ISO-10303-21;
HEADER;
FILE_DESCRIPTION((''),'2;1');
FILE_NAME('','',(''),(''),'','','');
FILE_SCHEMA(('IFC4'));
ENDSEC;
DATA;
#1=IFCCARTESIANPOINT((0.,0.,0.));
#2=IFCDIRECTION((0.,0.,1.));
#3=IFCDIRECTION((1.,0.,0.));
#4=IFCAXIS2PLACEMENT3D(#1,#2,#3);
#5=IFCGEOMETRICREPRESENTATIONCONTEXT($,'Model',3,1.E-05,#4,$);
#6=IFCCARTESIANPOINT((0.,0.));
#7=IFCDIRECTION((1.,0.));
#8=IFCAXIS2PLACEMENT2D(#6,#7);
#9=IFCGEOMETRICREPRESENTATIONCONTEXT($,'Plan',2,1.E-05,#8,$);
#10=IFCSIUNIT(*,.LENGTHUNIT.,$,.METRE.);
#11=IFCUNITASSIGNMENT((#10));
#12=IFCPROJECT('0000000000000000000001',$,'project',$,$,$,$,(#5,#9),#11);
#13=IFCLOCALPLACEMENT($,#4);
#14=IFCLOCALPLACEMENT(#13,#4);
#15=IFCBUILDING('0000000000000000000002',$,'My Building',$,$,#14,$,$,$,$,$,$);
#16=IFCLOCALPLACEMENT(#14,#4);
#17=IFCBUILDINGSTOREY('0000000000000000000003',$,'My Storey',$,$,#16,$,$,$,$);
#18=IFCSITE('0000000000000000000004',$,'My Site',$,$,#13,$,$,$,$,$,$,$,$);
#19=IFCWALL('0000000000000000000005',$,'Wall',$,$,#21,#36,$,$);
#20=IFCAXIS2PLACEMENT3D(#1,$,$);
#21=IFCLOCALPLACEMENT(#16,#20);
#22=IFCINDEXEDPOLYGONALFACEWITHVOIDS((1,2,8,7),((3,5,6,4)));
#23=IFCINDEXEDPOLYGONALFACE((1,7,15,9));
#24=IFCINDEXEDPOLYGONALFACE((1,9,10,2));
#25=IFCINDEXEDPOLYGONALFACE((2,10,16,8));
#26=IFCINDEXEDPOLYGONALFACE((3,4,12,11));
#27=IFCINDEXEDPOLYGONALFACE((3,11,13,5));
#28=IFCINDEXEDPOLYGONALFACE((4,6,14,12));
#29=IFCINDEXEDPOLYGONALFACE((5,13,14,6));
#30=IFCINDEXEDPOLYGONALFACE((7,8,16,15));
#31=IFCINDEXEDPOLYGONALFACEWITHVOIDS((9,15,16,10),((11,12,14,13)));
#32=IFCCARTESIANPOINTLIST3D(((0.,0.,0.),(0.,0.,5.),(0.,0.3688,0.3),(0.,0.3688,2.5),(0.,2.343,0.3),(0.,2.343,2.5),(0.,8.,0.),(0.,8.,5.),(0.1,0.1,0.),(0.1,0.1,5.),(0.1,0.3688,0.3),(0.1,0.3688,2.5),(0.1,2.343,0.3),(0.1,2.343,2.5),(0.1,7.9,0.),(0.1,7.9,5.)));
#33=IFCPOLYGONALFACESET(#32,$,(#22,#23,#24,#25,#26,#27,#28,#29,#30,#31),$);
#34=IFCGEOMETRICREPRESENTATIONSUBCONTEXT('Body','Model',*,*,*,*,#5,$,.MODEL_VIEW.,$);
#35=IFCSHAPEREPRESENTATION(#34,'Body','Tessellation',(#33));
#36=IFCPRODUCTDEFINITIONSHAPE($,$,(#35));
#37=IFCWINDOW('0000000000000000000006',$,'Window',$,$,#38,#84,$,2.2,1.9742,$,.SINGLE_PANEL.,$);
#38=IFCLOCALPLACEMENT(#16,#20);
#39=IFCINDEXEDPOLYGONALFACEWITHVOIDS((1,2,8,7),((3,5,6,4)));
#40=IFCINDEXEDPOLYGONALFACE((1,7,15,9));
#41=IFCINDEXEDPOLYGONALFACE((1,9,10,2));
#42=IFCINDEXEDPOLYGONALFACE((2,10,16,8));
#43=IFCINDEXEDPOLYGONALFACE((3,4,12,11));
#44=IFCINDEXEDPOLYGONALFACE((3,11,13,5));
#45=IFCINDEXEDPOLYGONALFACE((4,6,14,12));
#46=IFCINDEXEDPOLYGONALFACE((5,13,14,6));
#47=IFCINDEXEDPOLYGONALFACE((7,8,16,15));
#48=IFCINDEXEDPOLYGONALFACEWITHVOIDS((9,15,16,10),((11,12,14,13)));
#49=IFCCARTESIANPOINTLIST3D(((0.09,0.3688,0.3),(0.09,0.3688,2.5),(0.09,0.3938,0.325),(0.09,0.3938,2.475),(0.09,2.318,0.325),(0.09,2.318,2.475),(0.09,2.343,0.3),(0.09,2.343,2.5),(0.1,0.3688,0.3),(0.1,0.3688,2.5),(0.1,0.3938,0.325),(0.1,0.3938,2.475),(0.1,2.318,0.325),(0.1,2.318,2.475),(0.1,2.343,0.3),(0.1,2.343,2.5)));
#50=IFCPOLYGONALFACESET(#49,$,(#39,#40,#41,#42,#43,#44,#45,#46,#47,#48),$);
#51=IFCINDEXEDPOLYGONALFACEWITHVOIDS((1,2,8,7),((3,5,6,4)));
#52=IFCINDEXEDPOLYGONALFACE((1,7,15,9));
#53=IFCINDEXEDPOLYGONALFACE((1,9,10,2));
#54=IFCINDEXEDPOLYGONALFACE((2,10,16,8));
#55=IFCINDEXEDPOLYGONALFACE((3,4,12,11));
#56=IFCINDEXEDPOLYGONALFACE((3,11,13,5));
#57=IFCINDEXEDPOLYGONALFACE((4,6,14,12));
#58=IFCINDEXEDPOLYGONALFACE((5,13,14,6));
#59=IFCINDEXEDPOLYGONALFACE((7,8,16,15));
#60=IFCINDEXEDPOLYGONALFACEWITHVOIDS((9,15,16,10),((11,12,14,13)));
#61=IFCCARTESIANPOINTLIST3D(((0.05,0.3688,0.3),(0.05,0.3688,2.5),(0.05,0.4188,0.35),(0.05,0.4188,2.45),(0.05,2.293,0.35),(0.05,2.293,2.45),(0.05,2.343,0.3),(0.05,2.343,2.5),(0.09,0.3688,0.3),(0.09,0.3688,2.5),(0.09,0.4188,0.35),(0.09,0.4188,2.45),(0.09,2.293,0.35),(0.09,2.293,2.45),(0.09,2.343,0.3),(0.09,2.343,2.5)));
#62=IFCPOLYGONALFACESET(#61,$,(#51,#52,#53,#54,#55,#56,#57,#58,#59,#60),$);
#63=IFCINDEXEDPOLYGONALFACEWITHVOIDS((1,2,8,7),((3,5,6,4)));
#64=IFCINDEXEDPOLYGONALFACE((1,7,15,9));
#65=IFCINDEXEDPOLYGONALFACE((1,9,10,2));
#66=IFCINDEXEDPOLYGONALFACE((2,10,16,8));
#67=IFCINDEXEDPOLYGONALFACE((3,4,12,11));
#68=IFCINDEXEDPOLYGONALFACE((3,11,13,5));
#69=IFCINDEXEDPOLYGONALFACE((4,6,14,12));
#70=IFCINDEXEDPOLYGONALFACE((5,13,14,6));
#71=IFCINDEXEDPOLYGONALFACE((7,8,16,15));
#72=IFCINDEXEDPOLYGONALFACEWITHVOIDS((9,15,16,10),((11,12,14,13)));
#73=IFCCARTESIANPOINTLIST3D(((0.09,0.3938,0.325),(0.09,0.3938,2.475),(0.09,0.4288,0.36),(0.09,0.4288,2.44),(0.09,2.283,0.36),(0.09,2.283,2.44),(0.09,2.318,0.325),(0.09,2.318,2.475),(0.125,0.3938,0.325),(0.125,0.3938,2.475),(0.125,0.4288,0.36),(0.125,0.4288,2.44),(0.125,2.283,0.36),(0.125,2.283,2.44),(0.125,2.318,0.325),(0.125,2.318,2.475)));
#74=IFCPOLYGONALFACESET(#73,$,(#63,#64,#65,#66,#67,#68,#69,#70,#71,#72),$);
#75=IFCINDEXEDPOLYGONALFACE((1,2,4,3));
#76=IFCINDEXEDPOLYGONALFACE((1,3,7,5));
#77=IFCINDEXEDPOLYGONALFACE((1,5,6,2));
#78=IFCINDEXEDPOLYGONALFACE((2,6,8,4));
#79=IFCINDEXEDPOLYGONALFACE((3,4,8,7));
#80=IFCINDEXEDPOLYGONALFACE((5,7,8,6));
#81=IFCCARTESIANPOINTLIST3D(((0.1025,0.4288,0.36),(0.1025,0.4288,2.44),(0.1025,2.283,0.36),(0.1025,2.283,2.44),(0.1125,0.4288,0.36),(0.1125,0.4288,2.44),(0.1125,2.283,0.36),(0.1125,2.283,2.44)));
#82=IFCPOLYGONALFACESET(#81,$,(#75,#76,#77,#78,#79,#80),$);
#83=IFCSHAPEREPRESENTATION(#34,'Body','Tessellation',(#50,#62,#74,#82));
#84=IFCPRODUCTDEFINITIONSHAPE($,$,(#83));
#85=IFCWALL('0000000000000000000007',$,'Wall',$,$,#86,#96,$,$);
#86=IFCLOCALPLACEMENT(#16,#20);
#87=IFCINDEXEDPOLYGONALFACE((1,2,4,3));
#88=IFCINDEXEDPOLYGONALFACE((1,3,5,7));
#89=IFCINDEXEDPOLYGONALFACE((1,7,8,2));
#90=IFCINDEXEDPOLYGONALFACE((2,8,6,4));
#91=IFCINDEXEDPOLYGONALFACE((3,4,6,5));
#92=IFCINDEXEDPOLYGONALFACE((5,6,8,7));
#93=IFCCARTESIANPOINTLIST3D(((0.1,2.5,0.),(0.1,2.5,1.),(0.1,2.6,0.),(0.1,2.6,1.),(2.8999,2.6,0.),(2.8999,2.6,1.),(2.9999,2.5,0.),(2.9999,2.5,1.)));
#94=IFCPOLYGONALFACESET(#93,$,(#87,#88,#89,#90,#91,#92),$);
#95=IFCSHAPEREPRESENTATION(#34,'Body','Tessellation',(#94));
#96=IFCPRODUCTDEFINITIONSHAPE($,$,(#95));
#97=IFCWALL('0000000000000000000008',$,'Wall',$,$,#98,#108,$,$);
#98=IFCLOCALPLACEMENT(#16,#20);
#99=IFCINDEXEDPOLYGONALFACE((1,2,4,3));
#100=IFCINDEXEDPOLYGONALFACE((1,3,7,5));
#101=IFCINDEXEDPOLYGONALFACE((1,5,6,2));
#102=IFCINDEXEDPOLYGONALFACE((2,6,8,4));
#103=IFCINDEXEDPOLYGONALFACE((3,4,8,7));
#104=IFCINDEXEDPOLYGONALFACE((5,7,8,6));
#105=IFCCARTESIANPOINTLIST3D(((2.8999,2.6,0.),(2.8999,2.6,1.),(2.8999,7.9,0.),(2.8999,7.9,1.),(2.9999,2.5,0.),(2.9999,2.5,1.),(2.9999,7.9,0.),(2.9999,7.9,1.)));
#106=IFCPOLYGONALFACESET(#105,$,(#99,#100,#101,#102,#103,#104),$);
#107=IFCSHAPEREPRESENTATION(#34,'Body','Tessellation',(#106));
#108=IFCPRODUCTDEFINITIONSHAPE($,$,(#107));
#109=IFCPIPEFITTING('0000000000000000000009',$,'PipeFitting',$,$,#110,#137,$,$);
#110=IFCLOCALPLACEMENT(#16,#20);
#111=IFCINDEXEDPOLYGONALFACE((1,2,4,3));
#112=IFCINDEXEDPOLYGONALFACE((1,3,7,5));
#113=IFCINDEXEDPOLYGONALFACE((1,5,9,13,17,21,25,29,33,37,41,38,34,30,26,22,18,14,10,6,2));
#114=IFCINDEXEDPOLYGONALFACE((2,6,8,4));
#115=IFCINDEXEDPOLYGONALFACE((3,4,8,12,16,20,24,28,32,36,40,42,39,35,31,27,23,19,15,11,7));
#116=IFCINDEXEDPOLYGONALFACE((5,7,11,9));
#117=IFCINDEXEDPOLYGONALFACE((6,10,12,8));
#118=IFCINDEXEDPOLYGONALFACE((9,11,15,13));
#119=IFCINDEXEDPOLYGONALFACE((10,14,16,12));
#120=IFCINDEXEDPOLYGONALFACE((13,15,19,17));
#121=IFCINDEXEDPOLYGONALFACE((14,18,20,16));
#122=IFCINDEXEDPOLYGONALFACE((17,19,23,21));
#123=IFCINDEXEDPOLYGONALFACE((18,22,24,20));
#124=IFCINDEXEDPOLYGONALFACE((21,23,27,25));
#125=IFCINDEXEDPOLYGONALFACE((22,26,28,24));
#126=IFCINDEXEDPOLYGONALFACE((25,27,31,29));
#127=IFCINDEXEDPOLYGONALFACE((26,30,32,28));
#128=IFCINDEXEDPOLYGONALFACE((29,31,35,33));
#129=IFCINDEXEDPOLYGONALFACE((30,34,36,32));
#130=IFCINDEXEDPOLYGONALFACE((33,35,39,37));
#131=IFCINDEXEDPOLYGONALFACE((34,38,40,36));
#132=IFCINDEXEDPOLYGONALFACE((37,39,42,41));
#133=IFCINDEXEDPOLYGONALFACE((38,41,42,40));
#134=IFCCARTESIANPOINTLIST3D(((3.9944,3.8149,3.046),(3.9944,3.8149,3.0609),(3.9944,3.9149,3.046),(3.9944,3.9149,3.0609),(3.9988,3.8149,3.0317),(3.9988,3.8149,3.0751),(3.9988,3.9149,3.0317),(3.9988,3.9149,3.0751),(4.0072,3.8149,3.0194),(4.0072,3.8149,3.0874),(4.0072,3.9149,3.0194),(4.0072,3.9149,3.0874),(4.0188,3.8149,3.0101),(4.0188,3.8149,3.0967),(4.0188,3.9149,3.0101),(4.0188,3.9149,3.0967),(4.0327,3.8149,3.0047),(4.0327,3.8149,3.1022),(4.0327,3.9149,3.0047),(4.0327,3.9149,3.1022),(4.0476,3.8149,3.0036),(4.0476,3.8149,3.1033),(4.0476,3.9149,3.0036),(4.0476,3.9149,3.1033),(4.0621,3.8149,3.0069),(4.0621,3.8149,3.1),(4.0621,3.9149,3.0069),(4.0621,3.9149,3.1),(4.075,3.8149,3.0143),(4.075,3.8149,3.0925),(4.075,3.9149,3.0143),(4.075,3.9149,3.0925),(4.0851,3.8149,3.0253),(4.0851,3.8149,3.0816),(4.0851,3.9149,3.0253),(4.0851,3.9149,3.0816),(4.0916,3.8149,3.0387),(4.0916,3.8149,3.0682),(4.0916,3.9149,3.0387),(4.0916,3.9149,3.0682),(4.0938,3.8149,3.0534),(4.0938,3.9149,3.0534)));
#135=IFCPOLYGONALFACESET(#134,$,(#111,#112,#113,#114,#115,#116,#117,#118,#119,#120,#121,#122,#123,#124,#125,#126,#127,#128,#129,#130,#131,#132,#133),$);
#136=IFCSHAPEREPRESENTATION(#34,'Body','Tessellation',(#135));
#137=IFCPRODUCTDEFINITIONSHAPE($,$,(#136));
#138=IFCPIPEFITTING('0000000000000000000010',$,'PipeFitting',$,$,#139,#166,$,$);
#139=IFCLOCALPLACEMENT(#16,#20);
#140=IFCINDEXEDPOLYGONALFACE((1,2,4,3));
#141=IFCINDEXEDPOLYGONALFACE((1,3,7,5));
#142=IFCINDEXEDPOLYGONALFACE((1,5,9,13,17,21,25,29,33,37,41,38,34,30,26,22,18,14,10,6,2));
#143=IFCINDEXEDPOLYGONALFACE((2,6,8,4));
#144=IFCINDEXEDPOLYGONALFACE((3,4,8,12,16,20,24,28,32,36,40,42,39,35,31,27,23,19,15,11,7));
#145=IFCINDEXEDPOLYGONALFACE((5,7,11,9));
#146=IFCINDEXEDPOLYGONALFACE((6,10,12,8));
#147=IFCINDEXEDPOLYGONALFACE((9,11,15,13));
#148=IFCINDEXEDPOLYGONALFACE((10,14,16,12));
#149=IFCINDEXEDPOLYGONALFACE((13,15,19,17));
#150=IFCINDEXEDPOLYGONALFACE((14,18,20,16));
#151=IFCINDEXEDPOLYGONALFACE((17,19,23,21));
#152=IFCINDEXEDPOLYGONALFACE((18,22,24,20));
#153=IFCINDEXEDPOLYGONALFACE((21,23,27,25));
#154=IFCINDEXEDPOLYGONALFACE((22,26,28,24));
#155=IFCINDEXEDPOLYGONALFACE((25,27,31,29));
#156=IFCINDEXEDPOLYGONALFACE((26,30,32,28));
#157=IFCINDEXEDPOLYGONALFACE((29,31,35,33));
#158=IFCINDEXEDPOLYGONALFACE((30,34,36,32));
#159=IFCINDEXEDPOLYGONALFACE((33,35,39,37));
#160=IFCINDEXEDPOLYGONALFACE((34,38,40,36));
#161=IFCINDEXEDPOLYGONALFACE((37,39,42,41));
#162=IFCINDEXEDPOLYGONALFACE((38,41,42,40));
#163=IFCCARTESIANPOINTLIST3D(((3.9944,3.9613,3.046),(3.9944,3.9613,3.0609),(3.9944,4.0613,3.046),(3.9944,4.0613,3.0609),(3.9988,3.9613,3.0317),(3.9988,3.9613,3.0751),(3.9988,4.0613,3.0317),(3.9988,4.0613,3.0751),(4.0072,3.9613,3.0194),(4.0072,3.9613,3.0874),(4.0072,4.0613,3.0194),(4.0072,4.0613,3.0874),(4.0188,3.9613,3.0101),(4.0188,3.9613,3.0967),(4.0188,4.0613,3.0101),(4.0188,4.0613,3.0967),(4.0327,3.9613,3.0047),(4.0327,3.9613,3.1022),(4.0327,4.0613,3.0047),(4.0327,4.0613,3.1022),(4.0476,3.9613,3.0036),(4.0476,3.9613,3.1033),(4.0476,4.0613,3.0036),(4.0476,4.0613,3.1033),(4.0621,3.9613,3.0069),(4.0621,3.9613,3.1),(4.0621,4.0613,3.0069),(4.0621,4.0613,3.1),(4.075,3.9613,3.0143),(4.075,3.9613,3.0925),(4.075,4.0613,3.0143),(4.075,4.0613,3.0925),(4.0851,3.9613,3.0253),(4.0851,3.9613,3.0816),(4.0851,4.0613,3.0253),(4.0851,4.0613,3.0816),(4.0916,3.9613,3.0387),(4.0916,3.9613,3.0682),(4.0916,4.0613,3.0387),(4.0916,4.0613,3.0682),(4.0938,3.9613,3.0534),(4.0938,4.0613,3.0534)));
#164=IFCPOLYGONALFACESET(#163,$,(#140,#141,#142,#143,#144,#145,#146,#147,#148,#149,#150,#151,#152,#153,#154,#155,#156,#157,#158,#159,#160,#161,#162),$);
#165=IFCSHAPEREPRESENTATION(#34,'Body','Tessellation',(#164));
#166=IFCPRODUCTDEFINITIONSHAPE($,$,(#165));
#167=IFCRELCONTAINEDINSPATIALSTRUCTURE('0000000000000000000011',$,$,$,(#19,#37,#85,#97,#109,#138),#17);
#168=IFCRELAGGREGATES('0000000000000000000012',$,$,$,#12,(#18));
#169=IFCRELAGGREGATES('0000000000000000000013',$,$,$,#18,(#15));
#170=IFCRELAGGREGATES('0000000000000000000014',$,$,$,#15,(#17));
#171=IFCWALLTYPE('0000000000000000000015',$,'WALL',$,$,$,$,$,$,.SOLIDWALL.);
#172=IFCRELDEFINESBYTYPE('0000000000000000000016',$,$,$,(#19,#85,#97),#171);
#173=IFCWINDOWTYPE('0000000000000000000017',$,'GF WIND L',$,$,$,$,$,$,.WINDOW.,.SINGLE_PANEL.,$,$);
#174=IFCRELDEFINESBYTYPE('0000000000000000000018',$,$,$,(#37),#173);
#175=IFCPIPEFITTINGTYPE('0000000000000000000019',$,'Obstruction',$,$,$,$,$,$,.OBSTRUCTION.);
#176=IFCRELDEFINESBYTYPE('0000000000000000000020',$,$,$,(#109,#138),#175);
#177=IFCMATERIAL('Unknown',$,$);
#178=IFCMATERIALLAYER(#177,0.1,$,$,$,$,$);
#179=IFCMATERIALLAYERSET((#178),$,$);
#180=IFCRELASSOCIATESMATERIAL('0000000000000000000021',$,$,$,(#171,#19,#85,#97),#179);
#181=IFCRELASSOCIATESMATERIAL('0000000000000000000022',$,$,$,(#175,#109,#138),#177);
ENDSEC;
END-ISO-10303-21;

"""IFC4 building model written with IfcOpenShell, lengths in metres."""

from ifc_helpers import new_model, entity, si_unit, frame, origin_with_axes, origin_2d_with_axis, place, context, subcontext, project, spatial, line, indexed_curve, circle, outline, extrude, shape, source, transform, mapped, material, layer, layer_set, layer_usage, material_profile, profile_set, profile_usage, type_object, type_shapes, element, fill, save


model = new_model("IFC4")

# Units and contexts
model_context = context("Model", 3, precision=1e-05, world=origin_with_axes())
plan_context = context("Plan", 2, precision=1e-05, world=origin_2d_with_axis())
body_context_1 = subcontext(model_context, "Body", "Model", "MODEL_VIEW")
body_context_2 = subcontext(plan_context, "Body", "Plan", "PLAN_VIEW")
ifc_project = project(units=[si_unit("LENGTHUNIT", "METRE")], contexts=[model_context, plan_context])

# Site, building, storey
site_placement = place(None, origin_with_axes())
site = spatial("IfcSite", under=ifc_project, at=site_placement, Name="My Site")
building_placement = place(site_placement, origin_with_axes())
building = spatial("IfcBuilding", under=site, at=building_placement, Name="My Building")
storey_placement = place(building_placement, origin_with_axes())
storey = spatial("IfcBuildingStorey", under=building, at=storey_placement, Name="My Storey")

# Shared definitions
ifc_material = material(Name="Unknown")

# Shared definitions
ifc_layer_1 = layer(ifc_material, 0.1)
ifc_layer_set_1 = layer_set([ifc_layer_1])
wall_type = type_object("IfcWallType", Name="WALL", PredefinedType="SOLIDWALL", material=ifc_layer_set_1)

# Wall, opening, window
ifc_layer_usage_1 = layer_usage(ifc_layer_set_1, "AXIS2", "POSITIVE", 0.0)
wall_1_placement = place(storey_placement, frame((0.0, 8.0, 0.0), z_axis=(0.0, 0.0, 1.0), x_axis=(0.0, -1.0, 0.0)))
wall_1 = element("IfcWall", 1, at=wall_1_placement, inside=storey, type_object=wall_type, material=ifc_layer_usage_1, Name="Wall", context=body_context_1, shape_type="SweptSolid", body=[
    extrude(outline(indexed_curve([(0.0, 0.0), (0.1, 0.1), (7.9, 0.1), (8.0, 0.0)], segments=[line(1, 2, 3, 4, 1)])), origin_with_axes(), (0.0, 0.0, 1.0), 5.0),
])
shared_shape_1 = source(origin_with_axes(), body_context_1, "Body", "SweptSolid", [
    extrude(outline(indexed_curve([(0.0, 0.0), (1.9742, 0.0), (1.9742, 2.2), (0.0, 2.2)], segments=[line(1, 2, 3, 4, 1)])), frame((0.0, -0.6, 0.0), z_axis=(0.0, -1.0, 0.0), x_axis=(1.0, 0.0, 0.0)), (0.0, 0.0, -1.0), 1.2),
])
opening_1_placement = place(wall_1_placement, frame((5.657, 0.0, 0.3), z_axis=(0.0, 0.0, 1.0), x_axis=(1.0, 0.0, 0.0)))
opening_1 = element("IfcOpeningElement", 2, at=opening_1_placement, cuts=wall_1, PredefinedType="OPENING", context=body_context_1, shape_type="MappedRepresentation", body=[
    mapped(shared_shape_1, transform((0.0, 0.0, 0.0), x_axis=(1.0, 0.0, 0.0), y_axis=(0.0, 1.0, 0.0), z_axis=(0.0, 0.0, 1.0), scale=1.0)),
])
window_type_1 = type_object("IfcWindowType", Name="GF WIND L", PartitioningType="SINGLE_PANEL", PredefinedType="WINDOW")
shared_shape_2 = source(origin_with_axes(), body_context_1, "Body", "SweptSolid", [
    extrude(outline(indexed_curve([(0.0, 0.0), (1.9742, 0.0), (1.9742, 2.2), (0.0, 2.2)], segments=[line(1, 2, 3, 4, 1)]), holes=[indexed_curve([(0.025, 0.025), (1.9492, 0.025), (1.9492, 2.175), (0.025, 2.175)], segments=[line(1, 2, 3, 4, 1)])]), frame((0.0, 0.09, 0.0), z_axis=(0.0, -1.0, 0.0), x_axis=(1.0, 0.0, 0.0)), (0.0, 0.0, -1.0), 0.01),
    extrude(outline(indexed_curve([(0.0, 0.0), (1.9742, 0.0), (1.9742, 2.2), (0.0, 2.2)], segments=[line(1, 2, 3, 4, 1)]), holes=[indexed_curve([(0.05, 0.05), (1.9242, 0.05), (1.9242, 2.15), (0.05, 2.15)], segments=[line(1, 2, 3, 4, 1)])]), frame((0.0, 0.05, 0.0), z_axis=(0.0, -1.0, 0.0), x_axis=(1.0, 0.0, 0.0)), (0.0, 0.0, -1.0), 0.04),
    extrude(outline(indexed_curve([(0.0, 0.0), (1.9242, 0.0), (1.9242, 2.15), (0.0, 2.15)], segments=[line(1, 2, 3, 4, 1)]), holes=[indexed_curve([(0.035, 0.035), (1.8892, 0.035), (1.8892, 2.115), (0.035, 2.115)], segments=[line(1, 2, 3, 4, 1)])]), frame((0.025, 0.09, 0.025), z_axis=(0.0, -1.0, 0.0), x_axis=(1.0, 0.0, 0.0)), (0.0, 0.0, -1.0), 0.035),
    extrude(outline(indexed_curve([(0.035, 0.035), (1.8892, 0.035), (1.8892, 2.115), (0.035, 2.115)], segments=[line(1, 2, 3, 4, 1)])), frame((0.025, 0.1025, 0.025), z_axis=(0.0, -1.0, 0.0), x_axis=(1.0, 0.0, 0.0)), (0.0, 0.0, -1.0), 0.01),
])
shared_shape_3 = source(origin_with_axes(), body_context_2, "Body", "Curve2D", [
    entity("IfcIndexedPolyCurve", entity("IfcCartesianPointList2D", [[0.05, 0.05], [1.9242, 0.05]])),
    entity("IfcIndexedPolyCurve", entity("IfcCartesianPointList2D", [[0.0, 0.1], [0.025, 0.1], [0.025, 0.09], [0.05, 0.09], [0.05, 0.05], [0.0, 0.05]]), [entity("IfcLineIndex", [1, 2, 3, 4, 5, 6, 1])]),
    entity("IfcIndexedPolyCurve", entity("IfcCartesianPointList2D", [[1.9742, 0.1], [1.9492, 0.1], [1.9492, 0.09], [1.9242, 0.09], [1.9242, 0.05], [1.9742, 0.05]]), [entity("IfcLineIndex", [1, 2, 3, 4, 5, 6, 1])]),
    entity("IfcIndexedPolyCurve", entity("IfcCartesianPointList2D", [[0.025, 0.09], [0.06, 0.09], [0.06, 0.125], [0.025, 0.125]]), [entity("IfcLineIndex", [1, 2, 3, 4, 1])]),
    entity("IfcIndexedPolyCurve", entity("IfcCartesianPointList2D", [[1.9492, 0.09], [1.9142, 0.09], [1.9142, 0.125], [1.9492, 0.125]]), [entity("IfcLineIndex", [1, 2, 3, 4, 1])]),
    entity("IfcIndexedPolyCurve", entity("IfcCartesianPointList2D", [[0.06, 0.09], [1.9142, 0.09]])),
    entity("IfcIndexedPolyCurve", entity("IfcCartesianPointList2D", [[0.06, 0.125], [1.9142, 0.125]])),
    entity("IfcIndexedPolyCurve", entity("IfcCartesianPointList2D", [[0.06, 0.1075], [1.9142, 0.1075]])),
])
type_shapes(window_type_1, [shared_shape_2, shared_shape_3])
window_1_placement = place(opening_1_placement, frame((0.0, 0.0, 0.0), z_axis=(0.0, 0.0, 1.0), x_axis=(1.0, 0.0, 0.0)))
window_1 = element("IfcWindow", 3, at=window_1_placement, inside=storey, type_object=window_type_1, Name="Window", OverallHeight=2.2, OverallWidth=1.9742, PartitioningType="SINGLE_PANEL", shapes=[
    shape(body_context_1, "Body", "MappedRepresentation", [mapped(shared_shape_2, transform((0.0, 0.0, 0.0), x_axis=(1.0, 0.0, 0.0), y_axis=(0.0, 1.0, 0.0), z_axis=(0.0, 0.0, 1.0), scale=1.0))]),
    shape(body_context_2, "Body", "MappedRepresentation", [mapped(shared_shape_3, transform((0.0, 0.0, 0.0), x_axis=(1.0, 0.0, 0.0), y_axis=(0.0, 1.0, 0.0), z_axis=(0.0, 0.0, 1.0), scale=1.0))]),
])
fill(opening_1, window_1)

# Walls
ifc_layer_usage_2 = layer_usage(ifc_layer_set_1, "AXIS2", "POSITIVE", 0.0)
wall_2_placement = place(storey_placement, frame((0.0, 2.5, 0.0), z_axis=(0.0, 0.0, 1.0), x_axis=(1.0, 0.0, 0.0)))
element("IfcWall", 4, at=wall_2_placement, inside=storey, type_object=wall_type, material=ifc_layer_usage_2, Name="Wall", context=body_context_1, shape_type="SweptSolid", body=[
    extrude(outline(indexed_curve([(0.1, 0.0), (0.1, 0.1), (2.8999, 0.1), (2.9999, 0.0)], segments=[line(1, 2, 3, 4, 1)])), origin_with_axes(), (0.0, 0.0, 1.0), 1.0),
])
ifc_layer_usage_3 = layer_usage(ifc_layer_set_1, "AXIS2", "POSITIVE", 0.0)
wall_3_placement = place(storey_placement, frame((2.9999, 2.5, 0.0), z_axis=(0.0, 0.0, 1.0), x_axis=(0.0, 1.0, 0.0)))
element("IfcWall", 5, at=wall_3_placement, inside=storey, type_object=wall_type, material=ifc_layer_usage_3, Name="Wall", context=body_context_1, shape_type="SweptSolid", body=[
    extrude(outline(indexed_curve([(0.0, 0.0), (0.1, 0.1), (5.4, 0.1), (5.4, 0.0)], segments=[line(1, 2, 3, 4, 1)])), origin_with_axes(), (0.0, 0.0, 1.0), 1.0),
])

# Pipe fittings
ifc_material_profile_1 = material_profile(ifc_material, circle(Radius=0.05))
ifc_profile_set_1 = profile_set([ifc_material_profile_1])
ifc_profile_usage_1 = profile_usage(ifc_profile_set_1, cardinal=5)
pipe_fitting_type = type_object("IfcPipeFittingType", Name="Obstruction", PredefinedType="OBSTRUCTION", material=ifc_profile_set_1)
pipe_fitting_1_placement = place(storey_placement, frame((4.0438, 3.9149, 3.0534), z_axis=(0.0, -1.0, 0.000001), x_axis=(1.0, 0.0, 0.0)))
element("IfcPipeFitting", 6, at=pipe_fitting_1_placement, inside=storey, type_object=pipe_fitting_type, material=ifc_profile_usage_1, Name="PipeFitting", context=body_context_1, shape_type="SweptSolid", body=[
    extrude(circle(Radius=0.05), origin_with_axes(), (0.0, 0.0, 1.0), 0.1),
])
ifc_profile_usage_2 = profile_usage(ifc_profile_set_1, cardinal=5)
pipe_fitting_2_placement = place(storey_placement, frame((4.0438, 4.0613, 3.0534), z_axis=(0.0, -1.0, 0.0), x_axis=(1.0, 0.0, 0.0)))
element("IfcPipeFitting", 7, at=pipe_fitting_2_placement, inside=storey, type_object=pipe_fitting_type, material=ifc_profile_usage_2, Name="PipeFitting", context=body_context_1, shape_type="SweptSolid", body=[
    extrude(circle(Radius=0.05), origin_with_axes(), (0.0, 0.0, 1.0), 0.1),
])

save(model, "model.ifc")
